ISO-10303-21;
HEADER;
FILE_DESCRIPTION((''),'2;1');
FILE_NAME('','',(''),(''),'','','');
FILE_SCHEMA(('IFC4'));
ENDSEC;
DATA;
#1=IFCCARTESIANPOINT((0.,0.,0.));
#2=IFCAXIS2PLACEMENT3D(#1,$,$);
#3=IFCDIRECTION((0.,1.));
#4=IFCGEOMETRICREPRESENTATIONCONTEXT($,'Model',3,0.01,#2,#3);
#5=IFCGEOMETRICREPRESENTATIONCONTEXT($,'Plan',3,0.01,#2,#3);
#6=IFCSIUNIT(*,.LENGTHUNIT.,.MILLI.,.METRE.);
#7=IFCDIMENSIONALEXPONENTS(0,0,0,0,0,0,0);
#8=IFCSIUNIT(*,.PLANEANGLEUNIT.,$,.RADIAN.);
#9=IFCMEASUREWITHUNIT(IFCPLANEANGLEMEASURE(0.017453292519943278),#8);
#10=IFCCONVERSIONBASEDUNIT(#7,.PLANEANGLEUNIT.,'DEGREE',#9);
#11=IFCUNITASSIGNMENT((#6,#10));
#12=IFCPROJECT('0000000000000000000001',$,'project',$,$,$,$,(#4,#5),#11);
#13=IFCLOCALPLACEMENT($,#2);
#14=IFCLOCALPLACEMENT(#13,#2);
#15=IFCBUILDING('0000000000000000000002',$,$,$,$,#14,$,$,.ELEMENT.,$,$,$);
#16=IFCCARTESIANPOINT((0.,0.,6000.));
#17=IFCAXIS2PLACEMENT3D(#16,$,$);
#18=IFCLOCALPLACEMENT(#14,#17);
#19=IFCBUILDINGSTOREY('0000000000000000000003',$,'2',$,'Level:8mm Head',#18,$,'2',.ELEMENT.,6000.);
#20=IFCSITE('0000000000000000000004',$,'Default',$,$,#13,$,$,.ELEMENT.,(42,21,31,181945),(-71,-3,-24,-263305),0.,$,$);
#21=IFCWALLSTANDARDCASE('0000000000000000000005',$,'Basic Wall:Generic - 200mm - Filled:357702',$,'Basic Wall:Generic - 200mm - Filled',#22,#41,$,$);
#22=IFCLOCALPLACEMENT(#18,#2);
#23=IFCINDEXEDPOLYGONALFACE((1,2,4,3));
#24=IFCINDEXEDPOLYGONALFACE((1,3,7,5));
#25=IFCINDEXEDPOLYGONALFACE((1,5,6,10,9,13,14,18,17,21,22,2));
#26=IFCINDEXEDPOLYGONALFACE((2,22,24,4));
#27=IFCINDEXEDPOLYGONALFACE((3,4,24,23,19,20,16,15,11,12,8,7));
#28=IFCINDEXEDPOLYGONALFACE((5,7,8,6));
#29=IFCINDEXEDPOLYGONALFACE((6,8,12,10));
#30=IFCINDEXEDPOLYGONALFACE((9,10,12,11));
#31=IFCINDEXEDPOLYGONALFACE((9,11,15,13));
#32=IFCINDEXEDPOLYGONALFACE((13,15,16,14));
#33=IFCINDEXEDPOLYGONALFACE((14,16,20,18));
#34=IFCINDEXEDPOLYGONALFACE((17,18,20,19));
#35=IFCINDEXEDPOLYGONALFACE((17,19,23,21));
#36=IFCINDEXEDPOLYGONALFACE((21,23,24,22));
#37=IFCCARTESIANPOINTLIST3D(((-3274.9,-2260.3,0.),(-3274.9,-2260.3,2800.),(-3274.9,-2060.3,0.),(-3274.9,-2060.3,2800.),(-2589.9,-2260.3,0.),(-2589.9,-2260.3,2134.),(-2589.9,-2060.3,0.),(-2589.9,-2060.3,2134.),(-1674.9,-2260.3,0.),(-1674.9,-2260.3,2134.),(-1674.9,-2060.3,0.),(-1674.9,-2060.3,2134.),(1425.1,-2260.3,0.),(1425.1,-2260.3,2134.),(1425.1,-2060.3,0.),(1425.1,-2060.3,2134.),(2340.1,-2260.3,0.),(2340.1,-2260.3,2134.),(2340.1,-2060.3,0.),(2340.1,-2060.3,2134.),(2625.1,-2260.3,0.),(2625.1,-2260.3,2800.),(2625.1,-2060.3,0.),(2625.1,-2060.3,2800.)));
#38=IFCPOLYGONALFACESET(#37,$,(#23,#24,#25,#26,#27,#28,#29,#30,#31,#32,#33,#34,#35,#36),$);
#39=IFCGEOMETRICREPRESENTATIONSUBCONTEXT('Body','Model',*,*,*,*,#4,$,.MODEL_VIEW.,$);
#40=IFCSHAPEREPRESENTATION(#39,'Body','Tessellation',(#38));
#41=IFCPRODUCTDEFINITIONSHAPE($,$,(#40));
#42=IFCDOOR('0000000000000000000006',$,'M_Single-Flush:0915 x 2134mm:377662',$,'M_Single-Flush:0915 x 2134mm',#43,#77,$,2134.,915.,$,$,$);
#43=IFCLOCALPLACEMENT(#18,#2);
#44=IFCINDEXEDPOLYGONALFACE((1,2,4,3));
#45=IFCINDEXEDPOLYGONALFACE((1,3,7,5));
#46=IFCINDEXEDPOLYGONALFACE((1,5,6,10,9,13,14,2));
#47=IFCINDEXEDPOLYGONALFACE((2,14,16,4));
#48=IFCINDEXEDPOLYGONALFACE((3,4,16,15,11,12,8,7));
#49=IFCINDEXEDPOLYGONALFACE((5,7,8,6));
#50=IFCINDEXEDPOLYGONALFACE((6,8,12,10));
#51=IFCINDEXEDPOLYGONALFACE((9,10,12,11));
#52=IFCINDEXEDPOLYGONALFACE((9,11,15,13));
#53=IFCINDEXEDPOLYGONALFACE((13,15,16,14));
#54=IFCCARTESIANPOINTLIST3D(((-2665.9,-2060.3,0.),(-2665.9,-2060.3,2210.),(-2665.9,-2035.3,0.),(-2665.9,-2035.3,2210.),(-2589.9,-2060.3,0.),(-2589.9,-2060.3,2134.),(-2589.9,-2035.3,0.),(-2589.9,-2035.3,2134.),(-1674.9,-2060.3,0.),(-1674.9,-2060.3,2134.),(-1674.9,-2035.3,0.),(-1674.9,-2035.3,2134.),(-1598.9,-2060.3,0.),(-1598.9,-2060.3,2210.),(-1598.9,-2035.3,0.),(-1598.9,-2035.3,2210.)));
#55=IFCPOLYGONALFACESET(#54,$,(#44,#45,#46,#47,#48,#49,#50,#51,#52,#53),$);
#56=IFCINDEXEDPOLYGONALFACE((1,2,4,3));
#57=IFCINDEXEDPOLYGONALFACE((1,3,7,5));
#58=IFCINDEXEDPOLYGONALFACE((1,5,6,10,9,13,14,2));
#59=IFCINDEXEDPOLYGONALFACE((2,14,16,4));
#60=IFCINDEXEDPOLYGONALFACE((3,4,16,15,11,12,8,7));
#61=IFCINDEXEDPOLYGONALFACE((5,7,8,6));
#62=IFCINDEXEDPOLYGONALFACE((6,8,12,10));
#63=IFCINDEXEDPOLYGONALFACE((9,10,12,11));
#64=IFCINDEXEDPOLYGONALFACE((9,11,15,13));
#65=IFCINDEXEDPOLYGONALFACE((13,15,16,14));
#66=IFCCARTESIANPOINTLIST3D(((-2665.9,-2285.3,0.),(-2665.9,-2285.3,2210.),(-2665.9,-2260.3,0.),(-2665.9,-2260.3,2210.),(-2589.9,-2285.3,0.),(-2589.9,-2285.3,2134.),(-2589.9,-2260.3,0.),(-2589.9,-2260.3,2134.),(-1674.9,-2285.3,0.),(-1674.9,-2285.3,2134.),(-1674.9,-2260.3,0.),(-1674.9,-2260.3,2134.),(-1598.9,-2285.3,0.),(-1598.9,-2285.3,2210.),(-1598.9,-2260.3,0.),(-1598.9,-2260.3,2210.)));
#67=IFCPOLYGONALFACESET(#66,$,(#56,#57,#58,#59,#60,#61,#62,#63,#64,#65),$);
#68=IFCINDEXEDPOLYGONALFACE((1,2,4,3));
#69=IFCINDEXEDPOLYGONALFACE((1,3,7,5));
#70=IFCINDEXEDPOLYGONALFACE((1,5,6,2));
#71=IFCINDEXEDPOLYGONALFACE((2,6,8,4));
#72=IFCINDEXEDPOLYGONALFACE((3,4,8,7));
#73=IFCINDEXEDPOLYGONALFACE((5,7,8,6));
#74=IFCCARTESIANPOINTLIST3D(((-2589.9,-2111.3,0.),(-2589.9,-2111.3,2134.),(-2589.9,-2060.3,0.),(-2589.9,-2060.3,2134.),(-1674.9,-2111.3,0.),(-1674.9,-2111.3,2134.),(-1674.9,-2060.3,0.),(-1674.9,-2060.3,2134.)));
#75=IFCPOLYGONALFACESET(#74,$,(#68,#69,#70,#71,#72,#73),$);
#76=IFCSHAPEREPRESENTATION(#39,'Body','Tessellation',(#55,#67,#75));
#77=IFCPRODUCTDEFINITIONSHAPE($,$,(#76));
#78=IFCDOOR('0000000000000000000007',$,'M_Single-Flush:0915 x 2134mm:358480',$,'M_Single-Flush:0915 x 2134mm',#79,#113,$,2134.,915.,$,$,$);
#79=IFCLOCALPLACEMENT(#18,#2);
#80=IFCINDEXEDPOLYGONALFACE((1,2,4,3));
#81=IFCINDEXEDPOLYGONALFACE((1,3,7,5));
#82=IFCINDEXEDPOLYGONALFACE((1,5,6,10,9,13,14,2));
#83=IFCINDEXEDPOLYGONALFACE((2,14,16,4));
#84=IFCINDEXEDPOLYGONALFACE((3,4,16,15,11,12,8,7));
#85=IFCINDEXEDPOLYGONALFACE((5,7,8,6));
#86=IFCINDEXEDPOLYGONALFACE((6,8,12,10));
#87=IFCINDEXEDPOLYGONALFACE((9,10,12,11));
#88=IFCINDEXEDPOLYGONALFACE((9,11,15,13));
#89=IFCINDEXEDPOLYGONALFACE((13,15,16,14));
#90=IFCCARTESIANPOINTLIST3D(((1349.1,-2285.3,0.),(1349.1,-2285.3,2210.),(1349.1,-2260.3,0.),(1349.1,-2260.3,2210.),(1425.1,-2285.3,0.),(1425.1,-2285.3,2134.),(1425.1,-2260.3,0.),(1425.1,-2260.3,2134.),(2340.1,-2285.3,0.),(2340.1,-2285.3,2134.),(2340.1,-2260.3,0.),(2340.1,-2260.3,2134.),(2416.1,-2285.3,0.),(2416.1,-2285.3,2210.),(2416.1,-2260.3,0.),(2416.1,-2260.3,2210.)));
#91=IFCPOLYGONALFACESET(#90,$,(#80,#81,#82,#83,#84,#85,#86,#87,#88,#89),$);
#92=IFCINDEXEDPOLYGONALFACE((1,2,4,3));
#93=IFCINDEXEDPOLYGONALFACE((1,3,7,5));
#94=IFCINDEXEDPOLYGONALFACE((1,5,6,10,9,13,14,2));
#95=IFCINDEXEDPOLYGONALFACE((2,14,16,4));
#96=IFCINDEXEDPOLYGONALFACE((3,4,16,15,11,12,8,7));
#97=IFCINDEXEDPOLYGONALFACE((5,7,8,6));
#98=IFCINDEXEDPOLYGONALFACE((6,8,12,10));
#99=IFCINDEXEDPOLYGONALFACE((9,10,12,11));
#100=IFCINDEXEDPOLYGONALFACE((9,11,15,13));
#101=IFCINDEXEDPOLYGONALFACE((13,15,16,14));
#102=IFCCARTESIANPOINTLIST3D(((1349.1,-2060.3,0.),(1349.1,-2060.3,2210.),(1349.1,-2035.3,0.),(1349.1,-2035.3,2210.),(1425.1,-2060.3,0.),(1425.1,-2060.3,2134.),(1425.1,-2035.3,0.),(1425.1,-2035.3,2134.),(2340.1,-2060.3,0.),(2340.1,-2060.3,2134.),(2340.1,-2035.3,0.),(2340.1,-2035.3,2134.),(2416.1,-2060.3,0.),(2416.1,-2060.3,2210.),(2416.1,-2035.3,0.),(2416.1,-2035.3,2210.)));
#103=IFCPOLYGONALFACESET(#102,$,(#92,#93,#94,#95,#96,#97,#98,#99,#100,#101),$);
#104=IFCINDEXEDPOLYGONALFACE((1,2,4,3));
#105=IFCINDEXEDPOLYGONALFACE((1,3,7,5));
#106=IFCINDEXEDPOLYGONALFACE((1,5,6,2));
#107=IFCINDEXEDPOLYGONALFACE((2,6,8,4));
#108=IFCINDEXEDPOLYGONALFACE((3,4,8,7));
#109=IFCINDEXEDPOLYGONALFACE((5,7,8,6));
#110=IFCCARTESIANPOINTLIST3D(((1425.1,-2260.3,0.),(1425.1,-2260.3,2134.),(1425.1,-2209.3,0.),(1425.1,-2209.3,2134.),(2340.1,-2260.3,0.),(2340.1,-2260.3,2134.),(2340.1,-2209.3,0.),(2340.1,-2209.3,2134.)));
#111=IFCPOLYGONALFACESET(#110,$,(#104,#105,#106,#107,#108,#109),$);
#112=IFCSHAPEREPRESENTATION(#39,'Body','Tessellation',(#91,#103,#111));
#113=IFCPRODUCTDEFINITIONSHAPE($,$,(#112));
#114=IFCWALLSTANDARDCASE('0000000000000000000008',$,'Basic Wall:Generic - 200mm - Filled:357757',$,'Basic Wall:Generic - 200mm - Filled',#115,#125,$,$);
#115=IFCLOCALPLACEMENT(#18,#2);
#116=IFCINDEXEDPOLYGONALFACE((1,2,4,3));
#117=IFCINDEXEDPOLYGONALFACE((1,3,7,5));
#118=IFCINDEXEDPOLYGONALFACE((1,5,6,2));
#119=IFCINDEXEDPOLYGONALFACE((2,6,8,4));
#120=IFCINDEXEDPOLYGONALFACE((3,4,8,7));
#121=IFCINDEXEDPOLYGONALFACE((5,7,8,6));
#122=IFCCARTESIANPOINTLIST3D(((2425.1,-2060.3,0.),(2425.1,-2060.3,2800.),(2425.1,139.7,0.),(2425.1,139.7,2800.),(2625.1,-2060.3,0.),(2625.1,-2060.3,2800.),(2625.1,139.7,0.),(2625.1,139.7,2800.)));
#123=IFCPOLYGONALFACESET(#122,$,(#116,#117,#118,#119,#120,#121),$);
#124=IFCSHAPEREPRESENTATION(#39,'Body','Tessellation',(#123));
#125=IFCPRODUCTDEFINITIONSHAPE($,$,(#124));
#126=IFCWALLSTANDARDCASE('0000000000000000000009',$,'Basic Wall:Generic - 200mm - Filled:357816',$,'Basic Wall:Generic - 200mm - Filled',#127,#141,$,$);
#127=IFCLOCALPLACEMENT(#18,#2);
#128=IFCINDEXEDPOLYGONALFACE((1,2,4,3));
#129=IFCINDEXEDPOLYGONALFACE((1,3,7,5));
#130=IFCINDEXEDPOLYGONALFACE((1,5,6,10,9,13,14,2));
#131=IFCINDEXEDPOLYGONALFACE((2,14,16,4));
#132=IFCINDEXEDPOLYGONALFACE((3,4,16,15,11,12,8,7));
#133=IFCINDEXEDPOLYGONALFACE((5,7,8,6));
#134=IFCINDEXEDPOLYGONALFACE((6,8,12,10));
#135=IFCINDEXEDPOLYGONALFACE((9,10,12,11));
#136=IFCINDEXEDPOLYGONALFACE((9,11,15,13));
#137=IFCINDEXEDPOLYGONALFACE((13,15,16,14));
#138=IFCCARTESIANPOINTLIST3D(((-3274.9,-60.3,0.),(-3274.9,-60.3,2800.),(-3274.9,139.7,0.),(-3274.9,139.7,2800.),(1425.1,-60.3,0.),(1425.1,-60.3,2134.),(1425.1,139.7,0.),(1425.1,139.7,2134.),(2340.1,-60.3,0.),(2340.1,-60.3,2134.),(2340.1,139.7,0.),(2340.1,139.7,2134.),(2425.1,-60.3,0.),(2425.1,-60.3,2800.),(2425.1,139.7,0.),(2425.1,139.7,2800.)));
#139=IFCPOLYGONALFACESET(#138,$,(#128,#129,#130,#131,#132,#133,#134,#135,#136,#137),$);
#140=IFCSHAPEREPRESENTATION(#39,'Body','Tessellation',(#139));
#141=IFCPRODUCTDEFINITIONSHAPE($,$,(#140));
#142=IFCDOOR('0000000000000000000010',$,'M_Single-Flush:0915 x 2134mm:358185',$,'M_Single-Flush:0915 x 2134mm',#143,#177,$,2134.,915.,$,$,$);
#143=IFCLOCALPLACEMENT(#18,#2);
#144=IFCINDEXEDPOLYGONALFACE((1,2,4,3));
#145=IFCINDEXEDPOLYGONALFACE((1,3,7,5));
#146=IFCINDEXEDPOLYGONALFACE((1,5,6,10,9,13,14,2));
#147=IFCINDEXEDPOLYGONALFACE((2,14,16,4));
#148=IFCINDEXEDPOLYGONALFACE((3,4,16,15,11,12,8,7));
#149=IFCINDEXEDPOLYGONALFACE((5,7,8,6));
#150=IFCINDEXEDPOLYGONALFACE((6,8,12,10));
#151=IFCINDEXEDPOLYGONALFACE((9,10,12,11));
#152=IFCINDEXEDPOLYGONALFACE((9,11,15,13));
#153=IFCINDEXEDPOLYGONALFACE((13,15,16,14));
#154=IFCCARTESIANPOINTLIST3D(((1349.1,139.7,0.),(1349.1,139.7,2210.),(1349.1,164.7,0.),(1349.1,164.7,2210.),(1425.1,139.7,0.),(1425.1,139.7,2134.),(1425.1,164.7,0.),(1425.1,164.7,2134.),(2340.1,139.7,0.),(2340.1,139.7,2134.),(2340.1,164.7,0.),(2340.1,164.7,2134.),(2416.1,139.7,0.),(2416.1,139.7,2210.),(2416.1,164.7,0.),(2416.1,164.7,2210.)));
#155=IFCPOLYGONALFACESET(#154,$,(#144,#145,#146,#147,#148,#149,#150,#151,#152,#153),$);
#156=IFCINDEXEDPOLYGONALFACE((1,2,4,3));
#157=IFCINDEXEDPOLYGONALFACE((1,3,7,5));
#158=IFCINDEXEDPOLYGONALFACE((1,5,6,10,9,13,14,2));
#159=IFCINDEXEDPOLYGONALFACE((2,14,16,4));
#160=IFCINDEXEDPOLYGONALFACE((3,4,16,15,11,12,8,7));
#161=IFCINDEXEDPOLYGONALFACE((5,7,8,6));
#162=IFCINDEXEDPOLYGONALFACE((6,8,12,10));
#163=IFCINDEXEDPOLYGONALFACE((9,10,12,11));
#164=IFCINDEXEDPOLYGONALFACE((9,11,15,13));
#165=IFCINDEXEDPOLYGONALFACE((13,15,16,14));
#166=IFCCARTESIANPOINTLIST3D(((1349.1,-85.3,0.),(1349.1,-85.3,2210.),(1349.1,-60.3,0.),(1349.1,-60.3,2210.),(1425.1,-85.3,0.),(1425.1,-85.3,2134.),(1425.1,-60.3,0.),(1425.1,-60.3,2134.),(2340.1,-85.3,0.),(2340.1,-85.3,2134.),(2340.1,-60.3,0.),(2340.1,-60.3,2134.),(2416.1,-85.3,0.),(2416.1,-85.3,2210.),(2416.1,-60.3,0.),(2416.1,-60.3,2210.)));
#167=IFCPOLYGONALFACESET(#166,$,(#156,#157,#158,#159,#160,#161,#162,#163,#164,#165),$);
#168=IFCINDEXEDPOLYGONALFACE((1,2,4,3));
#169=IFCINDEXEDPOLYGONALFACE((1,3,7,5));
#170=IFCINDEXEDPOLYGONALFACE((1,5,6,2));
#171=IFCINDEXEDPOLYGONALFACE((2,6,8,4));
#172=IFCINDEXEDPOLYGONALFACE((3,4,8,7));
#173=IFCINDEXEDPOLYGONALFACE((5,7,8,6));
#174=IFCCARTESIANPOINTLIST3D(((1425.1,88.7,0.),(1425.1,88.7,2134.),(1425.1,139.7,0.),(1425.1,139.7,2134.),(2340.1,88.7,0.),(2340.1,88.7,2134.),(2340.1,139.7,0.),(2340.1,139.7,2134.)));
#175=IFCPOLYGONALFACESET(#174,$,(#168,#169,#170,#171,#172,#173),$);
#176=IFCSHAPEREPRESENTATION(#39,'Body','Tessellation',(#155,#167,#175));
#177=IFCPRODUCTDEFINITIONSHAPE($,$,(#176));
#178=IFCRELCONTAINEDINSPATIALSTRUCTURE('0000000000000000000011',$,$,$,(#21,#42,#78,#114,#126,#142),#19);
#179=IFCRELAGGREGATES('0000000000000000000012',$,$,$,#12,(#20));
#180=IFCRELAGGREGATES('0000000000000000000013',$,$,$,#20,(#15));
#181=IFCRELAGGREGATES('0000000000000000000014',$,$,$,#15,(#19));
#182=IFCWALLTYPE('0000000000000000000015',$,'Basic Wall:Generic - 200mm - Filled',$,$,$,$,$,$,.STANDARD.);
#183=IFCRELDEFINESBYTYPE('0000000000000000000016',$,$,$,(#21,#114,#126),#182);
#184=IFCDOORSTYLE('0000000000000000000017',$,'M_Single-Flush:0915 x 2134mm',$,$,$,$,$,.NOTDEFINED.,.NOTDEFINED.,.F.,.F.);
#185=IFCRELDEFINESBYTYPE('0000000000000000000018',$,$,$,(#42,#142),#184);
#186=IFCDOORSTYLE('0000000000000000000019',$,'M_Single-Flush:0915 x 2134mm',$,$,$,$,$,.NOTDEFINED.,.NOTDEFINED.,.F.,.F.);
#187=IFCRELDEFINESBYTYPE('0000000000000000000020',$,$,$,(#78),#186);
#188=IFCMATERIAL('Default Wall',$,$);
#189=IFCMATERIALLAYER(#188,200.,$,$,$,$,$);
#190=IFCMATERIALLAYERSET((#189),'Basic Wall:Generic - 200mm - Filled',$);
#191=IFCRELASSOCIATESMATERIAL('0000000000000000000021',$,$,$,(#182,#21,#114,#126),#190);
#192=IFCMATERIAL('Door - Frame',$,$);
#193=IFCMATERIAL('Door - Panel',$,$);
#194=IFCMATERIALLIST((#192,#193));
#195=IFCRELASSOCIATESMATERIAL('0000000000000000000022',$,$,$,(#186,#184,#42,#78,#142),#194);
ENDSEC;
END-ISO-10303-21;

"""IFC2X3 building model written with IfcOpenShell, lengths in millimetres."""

from ifc_helpers import new_model, entity, si_unit, converted_unit, direction, frame, frame_2d, origin, place, context, subcontext, project, spatial, polyline, rectangle, outline, extrude, source, transform, mapped, material, material_list, layer, layer_set, layer_usage, type_object, type_shapes, element, fill, save


model = new_model("IFC2X3")

# Units and contexts
model_context = context("Model", 3, precision=0.01, world=origin(), true_north=direction((0.0, 1.0)))
plan_context = context("Plan", 3, precision=0.01, world=origin(), true_north=direction((0.0, 1.0)))
body_context = subcontext(model_context, "Body", "Model", "MODEL_VIEW")
ifc_project = project(units=[si_unit("LENGTHUNIT", "METRE", prefix="MILLI"), converted_unit("PLANEANGLEUNIT", "DEGREE", entity("IfcPlaneAngleMeasure", 0.017453292519943278), si_unit("PLANEANGLEUNIT", "RADIAN"), dimensions=[0, 0, 0, 0, 0, 0, 0])], contexts=[model_context, plan_context])

# Site, building, storey
site_placement = place(None, origin())
site = spatial("IfcSite", under=ifc_project, at=site_placement, Name="Default", CompositionType="ELEMENT", RefLatitude=(42, 21, 31, 181945), RefLongitude=(-71, -3, -24, -263305), RefElevation=0.0)
building_placement = place(site_placement, origin())
building = spatial("IfcBuilding", under=site, at=building_placement, CompositionType="ELEMENT")
storey_placement = place(building_placement, frame((0.0, 0.0, 6000.0)))
storey = spatial("IfcBuildingStorey", under=building, at=storey_placement, Name="2", ObjectType="Level:8mm Head", LongName="2", CompositionType="ELEMENT", Elevation=6000.0)

# Shared definitions
ifc_material_1 = material(Name="Default Wall")
ifc_layer_1 = layer(ifc_material_1, 200.0)
ifc_layer_set_1 = layer_set([ifc_layer_1], Name="Basic Wall:Generic - 200mm - Filled")
ifc_layer_usage_1 = layer_usage(ifc_layer_set_1, "AXIS2", "NEGATIVE", 100.0)
wall_type_1 = type_object("IfcWallType", Name="Basic Wall:Generic - 200mm - Filled", PredefinedType="STANDARD", material=ifc_layer_set_1)
ifc_material_2 = material(Name="Door - Frame")
ifc_material_3 = material(Name="Door - Panel")
ifc_material_list = material_list([ifc_material_2, ifc_material_3])
door_style_1 = type_object("IfcDoorStyle", Name="M_Single-Flush:0915 x 2134mm", ConstructionType="NOTDEFINED", OperationType="NOTDEFINED", ParameterTakesPrecedence=False, Sizeable=False, material=ifc_material_list)
shared_shape_1 = source(origin(), body_context, "Body", "SweptSolid", [
    extrude(outline(polyline([(-533.5, -1124.0), (533.5, -1124.0), (533.5, 1086.0), (457.5, 1086.0), (457.5, -1048.0), (-457.5, -1048.0), (-457.5, 1086.0), (-533.5, 1086.0), (-533.5, -1124.0)])), frame((457.5, 200.0, 1086.0), z_axis=(0.0, 1.0, 0.0), x_axis=(1.0, 0.0, 0.0)), (0.0, 0.0, 1.0), 25.0),
    extrude(outline(polyline([(-1124.0, -533.5), (1086.0, -533.5), (1086.0, -457.5), (-1048.0, -457.5), (-1048.0, 457.5), (1086.0, 457.5), (1086.0, 533.5), (-1124.0, 533.5), (-1124.0, -533.5)])), frame((457.5, -25.0, 1086.0), z_axis=(0.0, 1.0, 0.0), x_axis=(0.0, 0.0, -1.0)), (0.0, 0.0, 1.0), 25.0),
    extrude(rectangle(XDim=51.0, YDim=915.0, at=frame_2d((0.0, 0.0), x_axis=(1.0, 0.0))), frame((457.5, 174.5, 0.0), z_axis=(0.0, 0.0, 1.0), x_axis=(0.0, 1.0, 0.0)), (0.0, 0.0, 1.0), 2134.0),
])
type_shapes(door_style_1, [shared_shape_1])

# Wall, openings, doors
wall_1_placement = place(storey_placement, frame((-3274.9, -2160.3, 0.0)))
wall_1 = element("IfcWallStandardCase", 1, at=wall_1_placement, inside=storey, type_object=wall_type_1, material=ifc_layer_usage_1, Name="Basic Wall:Generic - 200mm - Filled:357702", ObjectType="Basic Wall:Generic - 200mm - Filled", context=body_context, shape_type="SweptSolid", body=[
    extrude(rectangle(XDim=5900.0, YDim=200.0, at=frame_2d((2950.0, 0.0), x_axis=(-1.0, 0.0))), origin(), (0.0, 0.0, 1.0), 2800.0),
])
opening_1_placement = place(wall_1_placement, frame((5615.0, 100.0, 0.0)))
opening_1 = element("IfcOpeningElement", 2, at=opening_1_placement, cuts=wall_1, ObjectType="Opening", context=body_context, shape_type="SweptSolid", body=[
    extrude(rectangle(XDim=915.0, YDim=2134.0, at=frame_2d((1067.0, 457.5), x_axis=(0.0, 1.0))), frame((0.0, 0.0, 0.0), z_axis=(0.0, -1.0, 0.0), x_axis=(0.0, 0.0, 1.0)), (0.0, 0.0, 1.0), 200.0),
])
opening_2_placement = place(wall_1_placement, frame((685.0, -100.0, 0.0)))
opening_2 = element("IfcOpeningElement", 3, at=opening_2_placement, cuts=wall_1, ObjectType="Opening", context=body_context, shape_type="SweptSolid", body=[
    extrude(rectangle(XDim=915.0, YDim=2134.0, at=frame_2d((1067.0, 457.5), x_axis=(0.0, -1.0))), frame((0.0, 0.0, 0.0), z_axis=(0.0, 1.0, 0.0), x_axis=(0.0, 0.0, 1.0)), (0.0, 0.0, 1.0), 200.0),
])
door_style_2 = type_object("IfcDoorStyle", Name="M_Single-Flush:0915 x 2134mm", ConstructionType="NOTDEFINED", OperationType="NOTDEFINED", ParameterTakesPrecedence=False, Sizeable=False, material=ifc_material_list)
shared_shape_2 = source(origin(), body_context, "Body", "SweptSolid", [
    extrude(outline(polyline([(-533.5, -1124.0), (533.5, -1124.0), (533.5, 1086.0), (457.5, 1086.0), (457.5, -1048.0), (-457.5, -1048.0), (-457.5, 1086.0), (-533.5, 1086.0), (-533.5, -1124.0)])), frame((457.5, 225.0, 1086.0), z_axis=(0.0, -1.0, 0.0), x_axis=(-1.0, 0.0, 0.0)), (0.0, 0.0, 1.0), 25.0),
    extrude(outline(polyline([(-1124.0, -533.5), (1086.0, -533.5), (1086.0, -457.5), (-1048.0, -457.5), (-1048.0, 457.5), (1086.0, 457.5), (1086.0, 533.5), (-1124.0, 533.5), (-1124.0, -533.5)])), frame((457.5, 0.0, 1086.0), z_axis=(0.0, -1.0, 0.0), x_axis=(0.0, 0.0, -1.0)), (0.0, 0.0, 1.0), 25.0),
    extrude(rectangle(XDim=915.0, YDim=51.0, at=frame_2d((0.0, 0.0), x_axis=(1.0, 0.0))), frame((457.5, 174.5, 0.0)), (0.0, 0.0, 1.0), 2134.0),
])
type_shapes(door_style_2, [shared_shape_2])
door_1_placement = place(opening_2_placement, origin())
door_1 = element("IfcDoor", 4, at=door_1_placement, inside=storey, type_object=door_style_2, material=ifc_material_list, Name="M_Single-Flush:0915 x 2134mm:377662", ObjectType="M_Single-Flush:0915 x 2134mm", OverallHeight=2134.0, OverallWidth=915.0, context=body_context, shape_type="MappedRepresentation", body=[
    mapped(shared_shape_2, transform((0.0, 0.0, 0.0), scale=1.0)),
])
fill(opening_2, door_1)
door_2_placement = place(opening_1_placement, frame((0.0, 0.0, 0.0), z_axis=(0.0, 0.0, 1.0), x_axis=(-1.0, 0.0, 0.0)))
door_2 = element("IfcDoor", 5, at=door_2_placement, inside=storey, type_object=door_style_1, material=ifc_material_list, Name="M_Single-Flush:0915 x 2134mm:358480", ObjectType="M_Single-Flush:0915 x 2134mm", OverallHeight=2134.0, OverallWidth=915.0, context=body_context, shape_type="MappedRepresentation", body=[
    mapped(shared_shape_1, transform((0.0, 0.0, 0.0), scale=1.0)),
])
fill(opening_1, door_2)

# Wall
wall_2_placement = place(storey_placement, frame((2525.1, -2060.3, 0.0), z_axis=(0.0, 0.0, 1.0), x_axis=(0.0, 1.0, 0.0)))
element("IfcWallStandardCase", 6, at=wall_2_placement, inside=storey, type_object=wall_type_1, material=ifc_layer_usage_1, Name="Basic Wall:Generic - 200mm - Filled:357757", ObjectType="Basic Wall:Generic - 200mm - Filled", context=body_context, shape_type="SweptSolid", body=[
    extrude(rectangle(XDim=2200.0, YDim=200.0, at=frame_2d((1100.0, 0.0), x_axis=(-1.0, 0.0))), origin(), (0.0, 0.0, 1.0), 2800.0),
])

# Wall, opening, door
wall_3_placement = place(storey_placement, frame((2425.1, 39.7, 0.0), z_axis=(0.0, 0.0, 1.0), x_axis=(-1.0, 0.0, 0.0)))
wall_3 = element("IfcWallStandardCase", 7, at=wall_3_placement, inside=storey, type_object=wall_type_1, material=ifc_layer_usage_1, Name="Basic Wall:Generic - 200mm - Filled:357816", ObjectType="Basic Wall:Generic - 200mm - Filled", context=body_context, shape_type="SweptSolid", body=[
    extrude(rectangle(XDim=5700.0, YDim=200.0, at=frame_2d((2850.0, 0.0), x_axis=(-1.0, 0.0))), origin(), (0.0, 0.0, 1.0), 2800.0),
])
opening_3_placement = place(wall_3_placement, frame((1000.0, 100.0, 0.0)))
opening_3 = element("IfcOpeningElement", 8, at=opening_3_placement, cuts=wall_3, ObjectType="Opening", context=body_context, shape_type="SweptSolid", body=[
    extrude(rectangle(XDim=915.0, YDim=2134.0, at=frame_2d((1067.0, 457.5), x_axis=(0.0, -1.0))), frame((0.0, 0.0, 0.0), z_axis=(0.0, -1.0, 0.0), x_axis=(0.0, 0.0, 1.0)), (0.0, 0.0, 1.0), 200.0),
])
door_3_placement = place(opening_3_placement, frame((0.0, 0.0, 0.0), z_axis=(0.0, 0.0, 1.0), x_axis=(-1.0, 0.0, 0.0)))
door_3 = element("IfcDoor", 9, at=door_3_placement, inside=storey, type_object=door_style_2, material=ifc_material_list, Name="M_Single-Flush:0915 x 2134mm:358185", ObjectType="M_Single-Flush:0915 x 2134mm", OverallHeight=2134.0, OverallWidth=915.0, context=body_context, shape_type="MappedRepresentation", body=[
    mapped(shared_shape_2, transform((0.0, 0.0, 0.0), scale=1.0)),
])
fill(opening_3, door_3)

save(model, "model.ifc")
